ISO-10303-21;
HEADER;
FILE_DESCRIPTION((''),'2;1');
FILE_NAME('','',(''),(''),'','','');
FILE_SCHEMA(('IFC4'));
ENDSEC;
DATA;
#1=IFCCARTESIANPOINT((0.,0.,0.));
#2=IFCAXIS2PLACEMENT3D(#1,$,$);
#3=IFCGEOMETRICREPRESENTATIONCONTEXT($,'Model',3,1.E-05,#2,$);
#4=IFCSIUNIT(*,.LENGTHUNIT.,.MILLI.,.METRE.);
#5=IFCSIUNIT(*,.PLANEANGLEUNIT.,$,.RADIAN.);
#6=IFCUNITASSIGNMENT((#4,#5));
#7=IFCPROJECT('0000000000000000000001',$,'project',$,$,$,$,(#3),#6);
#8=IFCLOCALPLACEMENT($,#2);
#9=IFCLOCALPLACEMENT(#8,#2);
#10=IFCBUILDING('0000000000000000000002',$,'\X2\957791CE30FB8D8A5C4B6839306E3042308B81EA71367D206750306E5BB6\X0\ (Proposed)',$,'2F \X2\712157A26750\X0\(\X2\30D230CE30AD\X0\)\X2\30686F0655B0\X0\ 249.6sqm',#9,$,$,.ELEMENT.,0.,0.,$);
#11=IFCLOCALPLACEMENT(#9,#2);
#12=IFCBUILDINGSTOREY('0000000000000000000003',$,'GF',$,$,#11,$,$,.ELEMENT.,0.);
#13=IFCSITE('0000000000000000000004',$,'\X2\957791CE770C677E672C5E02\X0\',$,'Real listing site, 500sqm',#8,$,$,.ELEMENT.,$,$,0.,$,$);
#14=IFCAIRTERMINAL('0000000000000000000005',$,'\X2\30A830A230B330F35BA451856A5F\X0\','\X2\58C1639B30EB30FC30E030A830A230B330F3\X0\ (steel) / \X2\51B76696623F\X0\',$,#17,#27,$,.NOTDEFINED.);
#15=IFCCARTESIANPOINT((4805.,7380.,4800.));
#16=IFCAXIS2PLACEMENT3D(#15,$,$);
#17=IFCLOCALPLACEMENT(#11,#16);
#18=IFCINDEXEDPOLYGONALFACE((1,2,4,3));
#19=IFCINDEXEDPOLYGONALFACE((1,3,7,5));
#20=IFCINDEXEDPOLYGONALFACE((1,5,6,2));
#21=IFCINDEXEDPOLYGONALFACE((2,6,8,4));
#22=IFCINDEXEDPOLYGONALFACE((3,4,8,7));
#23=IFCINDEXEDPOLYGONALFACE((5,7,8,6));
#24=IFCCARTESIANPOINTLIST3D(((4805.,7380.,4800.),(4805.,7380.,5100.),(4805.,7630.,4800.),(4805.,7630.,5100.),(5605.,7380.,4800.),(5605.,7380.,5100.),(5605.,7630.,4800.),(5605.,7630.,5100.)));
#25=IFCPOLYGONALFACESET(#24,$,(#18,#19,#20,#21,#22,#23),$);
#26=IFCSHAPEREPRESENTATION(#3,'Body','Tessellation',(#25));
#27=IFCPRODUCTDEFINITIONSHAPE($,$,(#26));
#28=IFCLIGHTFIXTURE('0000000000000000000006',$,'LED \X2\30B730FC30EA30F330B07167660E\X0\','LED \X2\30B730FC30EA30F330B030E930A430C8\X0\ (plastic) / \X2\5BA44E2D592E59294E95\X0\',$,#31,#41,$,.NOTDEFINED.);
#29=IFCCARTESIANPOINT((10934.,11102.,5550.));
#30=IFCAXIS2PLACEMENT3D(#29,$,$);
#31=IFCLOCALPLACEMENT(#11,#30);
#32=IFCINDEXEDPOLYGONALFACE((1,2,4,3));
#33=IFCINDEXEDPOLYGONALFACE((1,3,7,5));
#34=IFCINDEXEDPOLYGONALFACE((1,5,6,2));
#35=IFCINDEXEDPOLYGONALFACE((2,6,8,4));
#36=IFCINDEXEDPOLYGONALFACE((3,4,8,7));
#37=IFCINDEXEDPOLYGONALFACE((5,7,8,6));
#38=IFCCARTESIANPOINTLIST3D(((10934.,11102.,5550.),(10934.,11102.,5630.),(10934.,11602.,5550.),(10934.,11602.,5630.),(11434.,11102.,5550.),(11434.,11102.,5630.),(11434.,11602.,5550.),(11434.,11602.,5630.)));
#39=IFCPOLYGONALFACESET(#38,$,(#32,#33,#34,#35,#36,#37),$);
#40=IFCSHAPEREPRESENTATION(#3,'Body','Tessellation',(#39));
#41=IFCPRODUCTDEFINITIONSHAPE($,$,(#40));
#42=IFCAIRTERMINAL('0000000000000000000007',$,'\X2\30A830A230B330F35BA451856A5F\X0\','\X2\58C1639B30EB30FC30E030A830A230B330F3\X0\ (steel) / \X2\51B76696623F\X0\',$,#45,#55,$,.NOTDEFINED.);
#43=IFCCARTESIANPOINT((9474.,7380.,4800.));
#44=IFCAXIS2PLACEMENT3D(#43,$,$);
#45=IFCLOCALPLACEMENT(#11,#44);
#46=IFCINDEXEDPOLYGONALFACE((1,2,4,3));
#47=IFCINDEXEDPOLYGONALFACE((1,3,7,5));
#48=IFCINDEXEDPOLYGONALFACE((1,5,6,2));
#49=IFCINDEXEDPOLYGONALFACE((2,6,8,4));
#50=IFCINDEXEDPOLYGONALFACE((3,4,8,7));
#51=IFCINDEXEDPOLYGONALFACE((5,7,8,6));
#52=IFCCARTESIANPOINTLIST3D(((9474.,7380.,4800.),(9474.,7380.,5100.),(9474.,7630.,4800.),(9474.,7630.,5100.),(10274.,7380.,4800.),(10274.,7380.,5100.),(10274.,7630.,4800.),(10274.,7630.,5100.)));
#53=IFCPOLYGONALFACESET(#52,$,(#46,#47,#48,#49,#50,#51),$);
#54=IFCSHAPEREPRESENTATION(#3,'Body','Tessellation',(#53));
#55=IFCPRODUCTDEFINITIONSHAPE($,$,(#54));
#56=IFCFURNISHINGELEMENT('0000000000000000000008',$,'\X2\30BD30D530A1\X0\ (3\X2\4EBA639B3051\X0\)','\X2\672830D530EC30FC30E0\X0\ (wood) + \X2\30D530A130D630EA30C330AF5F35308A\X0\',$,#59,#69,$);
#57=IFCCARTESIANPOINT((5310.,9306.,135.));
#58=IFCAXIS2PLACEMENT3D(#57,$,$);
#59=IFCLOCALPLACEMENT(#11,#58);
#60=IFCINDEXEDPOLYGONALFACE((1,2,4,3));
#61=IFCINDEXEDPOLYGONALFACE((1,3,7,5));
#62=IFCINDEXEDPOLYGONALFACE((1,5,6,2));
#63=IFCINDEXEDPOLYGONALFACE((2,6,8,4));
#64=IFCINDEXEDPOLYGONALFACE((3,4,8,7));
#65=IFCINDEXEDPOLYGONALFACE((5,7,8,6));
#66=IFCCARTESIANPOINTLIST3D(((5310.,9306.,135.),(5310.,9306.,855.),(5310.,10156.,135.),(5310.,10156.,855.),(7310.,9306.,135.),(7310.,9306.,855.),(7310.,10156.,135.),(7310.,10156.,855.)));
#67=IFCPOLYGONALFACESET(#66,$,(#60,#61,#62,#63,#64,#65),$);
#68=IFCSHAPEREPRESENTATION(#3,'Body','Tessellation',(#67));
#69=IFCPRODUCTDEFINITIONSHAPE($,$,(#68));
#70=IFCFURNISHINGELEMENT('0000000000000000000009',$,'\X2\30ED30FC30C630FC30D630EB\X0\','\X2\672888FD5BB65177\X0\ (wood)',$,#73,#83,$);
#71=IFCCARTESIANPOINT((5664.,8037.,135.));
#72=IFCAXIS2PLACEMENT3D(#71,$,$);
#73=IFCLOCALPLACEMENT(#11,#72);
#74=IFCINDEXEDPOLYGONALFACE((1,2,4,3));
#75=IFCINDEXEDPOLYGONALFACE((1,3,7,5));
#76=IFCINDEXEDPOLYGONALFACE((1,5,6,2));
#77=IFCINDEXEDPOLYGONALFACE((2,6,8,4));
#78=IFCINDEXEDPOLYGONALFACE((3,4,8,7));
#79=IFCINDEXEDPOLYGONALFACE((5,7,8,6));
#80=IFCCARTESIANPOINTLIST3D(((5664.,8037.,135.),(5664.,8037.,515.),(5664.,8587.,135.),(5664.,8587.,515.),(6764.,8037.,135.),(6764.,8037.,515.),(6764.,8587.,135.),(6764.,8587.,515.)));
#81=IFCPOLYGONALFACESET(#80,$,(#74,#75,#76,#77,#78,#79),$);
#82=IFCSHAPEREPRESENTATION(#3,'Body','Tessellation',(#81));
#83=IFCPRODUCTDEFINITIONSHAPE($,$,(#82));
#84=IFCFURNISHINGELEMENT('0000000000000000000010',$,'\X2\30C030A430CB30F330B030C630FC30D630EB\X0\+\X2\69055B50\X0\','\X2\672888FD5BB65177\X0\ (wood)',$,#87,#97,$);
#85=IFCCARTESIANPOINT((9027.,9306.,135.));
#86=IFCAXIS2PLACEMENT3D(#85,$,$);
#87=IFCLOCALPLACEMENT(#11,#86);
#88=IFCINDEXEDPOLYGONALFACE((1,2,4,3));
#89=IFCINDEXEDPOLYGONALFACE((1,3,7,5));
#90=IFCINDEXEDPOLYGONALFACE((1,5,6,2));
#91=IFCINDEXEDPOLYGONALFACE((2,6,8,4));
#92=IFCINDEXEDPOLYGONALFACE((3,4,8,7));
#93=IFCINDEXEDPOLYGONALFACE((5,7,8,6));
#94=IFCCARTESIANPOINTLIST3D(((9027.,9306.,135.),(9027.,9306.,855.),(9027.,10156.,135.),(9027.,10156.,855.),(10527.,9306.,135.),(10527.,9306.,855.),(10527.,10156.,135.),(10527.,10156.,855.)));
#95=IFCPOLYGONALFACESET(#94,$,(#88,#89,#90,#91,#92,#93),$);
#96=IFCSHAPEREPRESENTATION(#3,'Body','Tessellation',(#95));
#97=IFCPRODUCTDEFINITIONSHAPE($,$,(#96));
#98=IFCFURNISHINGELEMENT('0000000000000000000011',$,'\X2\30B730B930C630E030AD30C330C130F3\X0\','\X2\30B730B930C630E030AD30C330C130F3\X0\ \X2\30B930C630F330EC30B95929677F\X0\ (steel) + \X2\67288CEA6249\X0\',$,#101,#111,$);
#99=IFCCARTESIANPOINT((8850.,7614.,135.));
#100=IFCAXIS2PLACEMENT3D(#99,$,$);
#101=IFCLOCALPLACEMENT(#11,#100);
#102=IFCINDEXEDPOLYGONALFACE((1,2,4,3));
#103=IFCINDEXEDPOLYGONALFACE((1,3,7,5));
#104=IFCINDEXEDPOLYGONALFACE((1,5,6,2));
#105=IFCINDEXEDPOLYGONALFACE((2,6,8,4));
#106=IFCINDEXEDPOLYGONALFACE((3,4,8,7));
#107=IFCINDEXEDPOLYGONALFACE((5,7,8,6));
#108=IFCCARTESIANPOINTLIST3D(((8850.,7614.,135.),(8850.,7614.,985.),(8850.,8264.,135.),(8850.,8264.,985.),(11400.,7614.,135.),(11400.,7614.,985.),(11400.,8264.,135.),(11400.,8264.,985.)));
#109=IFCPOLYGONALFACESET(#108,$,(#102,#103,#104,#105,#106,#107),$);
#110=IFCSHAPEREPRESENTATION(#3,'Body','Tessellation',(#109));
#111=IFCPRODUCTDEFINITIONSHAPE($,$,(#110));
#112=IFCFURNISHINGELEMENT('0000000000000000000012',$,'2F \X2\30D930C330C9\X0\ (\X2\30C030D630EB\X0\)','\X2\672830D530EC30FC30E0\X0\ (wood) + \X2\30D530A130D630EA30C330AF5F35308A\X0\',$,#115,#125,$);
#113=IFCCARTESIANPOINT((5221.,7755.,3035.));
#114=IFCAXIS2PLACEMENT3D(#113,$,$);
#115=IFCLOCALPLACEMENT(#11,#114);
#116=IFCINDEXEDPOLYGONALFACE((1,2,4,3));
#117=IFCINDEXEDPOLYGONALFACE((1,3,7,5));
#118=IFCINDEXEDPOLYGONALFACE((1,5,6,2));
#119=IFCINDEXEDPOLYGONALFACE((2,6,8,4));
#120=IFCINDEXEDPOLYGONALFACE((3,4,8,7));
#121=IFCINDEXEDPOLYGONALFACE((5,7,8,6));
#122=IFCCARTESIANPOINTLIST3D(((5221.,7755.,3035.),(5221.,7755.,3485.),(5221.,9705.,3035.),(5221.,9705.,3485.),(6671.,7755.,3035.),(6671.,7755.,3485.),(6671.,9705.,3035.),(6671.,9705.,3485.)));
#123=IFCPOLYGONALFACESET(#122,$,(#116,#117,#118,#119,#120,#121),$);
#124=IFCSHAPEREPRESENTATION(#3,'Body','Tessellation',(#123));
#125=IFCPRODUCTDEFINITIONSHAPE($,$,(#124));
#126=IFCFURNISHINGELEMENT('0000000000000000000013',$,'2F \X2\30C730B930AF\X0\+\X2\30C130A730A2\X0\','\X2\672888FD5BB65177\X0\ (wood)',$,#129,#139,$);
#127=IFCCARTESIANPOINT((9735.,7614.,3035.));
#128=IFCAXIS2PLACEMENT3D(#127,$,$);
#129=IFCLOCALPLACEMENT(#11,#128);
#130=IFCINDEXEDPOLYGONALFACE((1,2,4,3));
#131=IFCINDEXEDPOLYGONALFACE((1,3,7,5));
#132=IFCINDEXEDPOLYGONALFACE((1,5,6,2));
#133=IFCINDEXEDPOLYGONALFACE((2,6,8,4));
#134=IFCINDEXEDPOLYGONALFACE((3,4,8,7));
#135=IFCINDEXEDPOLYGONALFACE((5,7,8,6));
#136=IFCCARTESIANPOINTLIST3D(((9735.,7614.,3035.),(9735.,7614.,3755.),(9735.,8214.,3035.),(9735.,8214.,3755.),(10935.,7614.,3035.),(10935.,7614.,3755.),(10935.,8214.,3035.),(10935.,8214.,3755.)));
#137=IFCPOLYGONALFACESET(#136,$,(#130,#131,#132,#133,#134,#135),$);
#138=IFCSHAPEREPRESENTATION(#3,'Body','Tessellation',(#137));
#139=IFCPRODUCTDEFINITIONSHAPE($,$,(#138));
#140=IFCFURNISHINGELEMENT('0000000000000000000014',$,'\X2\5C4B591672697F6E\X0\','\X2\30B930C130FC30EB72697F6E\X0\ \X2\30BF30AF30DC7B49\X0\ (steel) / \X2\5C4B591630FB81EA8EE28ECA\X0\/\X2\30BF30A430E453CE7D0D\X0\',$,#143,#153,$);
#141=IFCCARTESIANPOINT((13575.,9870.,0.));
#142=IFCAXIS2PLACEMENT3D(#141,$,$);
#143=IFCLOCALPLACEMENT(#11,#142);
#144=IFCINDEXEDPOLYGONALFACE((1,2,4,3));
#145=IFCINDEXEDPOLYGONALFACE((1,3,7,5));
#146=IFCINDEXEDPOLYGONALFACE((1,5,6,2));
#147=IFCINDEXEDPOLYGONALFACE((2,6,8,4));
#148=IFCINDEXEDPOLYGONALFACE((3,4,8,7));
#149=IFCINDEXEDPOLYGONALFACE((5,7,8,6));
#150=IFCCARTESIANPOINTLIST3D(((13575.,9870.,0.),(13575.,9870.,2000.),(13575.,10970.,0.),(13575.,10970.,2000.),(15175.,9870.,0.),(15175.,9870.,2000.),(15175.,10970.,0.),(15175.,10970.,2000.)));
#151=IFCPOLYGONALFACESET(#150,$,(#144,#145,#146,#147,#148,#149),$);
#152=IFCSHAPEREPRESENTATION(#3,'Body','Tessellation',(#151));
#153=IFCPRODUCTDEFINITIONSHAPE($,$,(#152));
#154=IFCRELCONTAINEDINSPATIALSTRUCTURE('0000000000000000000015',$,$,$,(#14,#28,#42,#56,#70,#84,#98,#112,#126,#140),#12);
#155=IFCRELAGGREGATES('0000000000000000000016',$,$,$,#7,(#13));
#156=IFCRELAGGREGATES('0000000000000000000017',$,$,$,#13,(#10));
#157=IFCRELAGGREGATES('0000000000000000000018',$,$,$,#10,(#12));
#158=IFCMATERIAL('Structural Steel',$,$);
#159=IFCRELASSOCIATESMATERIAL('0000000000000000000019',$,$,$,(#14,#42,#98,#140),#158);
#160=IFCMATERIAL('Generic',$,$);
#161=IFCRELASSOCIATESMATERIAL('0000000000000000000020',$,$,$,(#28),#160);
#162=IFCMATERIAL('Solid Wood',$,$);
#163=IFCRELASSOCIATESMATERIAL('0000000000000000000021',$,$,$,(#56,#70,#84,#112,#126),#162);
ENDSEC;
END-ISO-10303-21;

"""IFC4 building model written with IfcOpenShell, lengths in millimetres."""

from ifc_helpers import new_model, si_unit, frame, frame_2d, origin, place, context, project, spatial, rectangle, extrude, material, element, save


model = new_model("IFC4")

# Units and contexts
model_context = context("Model", 3, precision=1e-05, world=origin())
ifc_project = project(units=[si_unit("LENGTHUNIT", "METRE", prefix="MILLI"), si_unit("PLANEANGLEUNIT", "RADIAN")], contexts=[model_context])

# Site, building, storey
site_placement = place(None, origin())
site = spatial("IfcSite", under=ifc_project, at=site_placement, Name="長野県松本市", ObjectType="Real listing site, 500sqm", CompositionType="ELEMENT", RefElevation=0.0)
building_placement = place(site_placement, origin())
building = spatial("IfcBuilding", under=site, at=building_placement, Name="長野・越屋根のある自然素材の家 (Proposed)", ObjectType="2F 無垢材(ヒノキ)と漆喰 249.6sqm", CompositionType="ELEMENT", ElevationOfRefHeight=0.0, ElevationOfTerrain=0.0)
storey_placement = place(building_placement, origin())
storey = spatial("IfcBuildingStorey", under=building, at=storey_placement, Name="GF", CompositionType="ELEMENT", Elevation=0.0)

# Shared definitions
ifc_material_1 = material(Name="Solid Wood")

# Shared definitions
ifc_material_2 = material(Name="Structural Steel")

# Shared definitions
ifc_material_3 = material(Name="Generic")

# Air terminal
air_terminal_1_placement = place(storey_placement, frame((4805.0, 7380.0, 4800.0)))
element("IfcAirTerminal", 1, at=air_terminal_1_placement, inside=storey, material=ifc_material_2, Name="エアコン室内機", Description="壁掛ルームエアコン (steel) / 冷暖房", PredefinedType="NOTDEFINED", context=model_context, shape_type="SweptSolid", body=[
    extrude(rectangle(XDim=800.0, YDim=250.0, at=frame_2d((400.0, 125.0))), frame((4805.0, 7380.0, 4800.0)), (0.0, 0.0, 1.0), 300.0),
])

# Light fixture
light_fixture_1_placement = place(storey_placement, frame((10934.0, 11102.0, 5550.0)))
element("IfcLightFixture", 2, at=light_fixture_1_placement, inside=storey, material=ifc_material_3, Name="LED シーリング照明", Description="LED シーリングライト (plastic) / 室中央天井", PredefinedType="NOTDEFINED", context=model_context, shape_type="SweptSolid", body=[
    extrude(rectangle(XDim=500.0, YDim=500.0, at=frame_2d((250.0, 250.0))), frame((10934.0, 11102.0, 5550.0)), (0.0, 0.0, 1.0), 80.0),
])

# Air terminal
air_terminal_2_placement = place(storey_placement, frame((9474.0, 7380.0, 4800.0)))
element("IfcAirTerminal", 3, at=air_terminal_2_placement, inside=storey, material=ifc_material_2, Name="エアコン室内機", Description="壁掛ルームエアコン (steel) / 冷暖房", PredefinedType="NOTDEFINED", context=model_context, shape_type="SweptSolid", body=[
    extrude(rectangle(XDim=800.0, YDim=250.0, at=frame_2d((400.0, 125.0))), frame((9474.0, 7380.0, 4800.0)), (0.0, 0.0, 1.0), 300.0),
])

# Furnishing elements
furnishing_1_placement = place(storey_placement, frame((5310.0, 9306.0, 135.0)))
element("IfcFurnishingElement", 4, at=furnishing_1_placement, inside=storey, material=ifc_material_1, Name="ソファ (3人掛け)", Description="木フレーム (wood) + ファブリック張り", context=model_context, shape_type="SweptSolid", body=[
    extrude(rectangle(XDim=2000.0, YDim=850.0, at=frame_2d((1000.0, 425.0))), frame((5310.0, 9306.0, 135.0)), (0.0, 0.0, 1.0), 720.0),
])
furnishing_2_placement = place(storey_placement, frame((5664.0, 8037.0, 135.0)))
element("IfcFurnishingElement", 5, at=furnishing_2_placement, inside=storey, material=ifc_material_1, Name="ローテーブル", Description="木製家具 (wood)", context=model_context, shape_type="SweptSolid", body=[
    extrude(rectangle(XDim=1100.0, YDim=550.0, at=frame_2d((550.0, 275.0))), frame((5664.0, 8037.0, 135.0)), (0.0, 0.0, 1.0), 380.0),
])
furnishing_3_placement = place(storey_placement, frame((9027.0, 9306.0, 135.0)))
element("IfcFurnishingElement", 6, at=furnishing_3_placement, inside=storey, material=ifc_material_1, Name="ダイニングテーブル+椅子", Description="木製家具 (wood)", context=model_context, shape_type="SweptSolid", body=[
    extrude(rectangle(XDim=1500.0, YDim=850.0, at=frame_2d((750.0, 425.0))), frame((9027.0, 9306.0, 135.0)), (0.0, 0.0, 1.0), 720.0),
])
furnishing_4_placement = place(storey_placement, frame((8850.0, 7614.0, 135.0)))
element("IfcFurnishingElement", 7, at=furnishing_4_placement, inside=storey, material=ifc_material_2, Name="システムキッチン", Description="システムキッチン ステンレス天板 (steel) + 木質扉", context=model_context, shape_type="SweptSolid", body=[
    extrude(rectangle(XDim=2550.0, YDim=650.0, at=frame_2d((1275.0, 325.0))), frame((8850.0, 7614.0, 135.0)), (0.0, 0.0, 1.0), 850.0),
])
furnishing_5_placement = place(storey_placement, frame((5221.0, 7755.0, 3035.0)))
element("IfcFurnishingElement", 8, at=furnishing_5_placement, inside=storey, material=ifc_material_1, Name="2F ベッド (ダブル)", Description="木フレーム (wood) + ファブリック張り", context=model_context, shape_type="SweptSolid", body=[
    extrude(rectangle(XDim=1450.0, YDim=1950.0, at=frame_2d((725.0, 975.0))), frame((5221.0, 7755.0, 3035.0)), (0.0, 0.0, 1.0), 450.0),
])
furnishing_6_placement = place(storey_placement, frame((9735.0, 7614.0, 3035.0)))
element("IfcFurnishingElement", 9, at=furnishing_6_placement, inside=storey, material=ifc_material_1, Name="2F デスク+チェア", Description="木製家具 (wood)", context=model_context, shape_type="SweptSolid", body=[
    extrude(rectangle(XDim=1200.0, YDim=600.0, at=frame_2d((600.0, 300.0))), frame((9735.0, 7614.0, 3035.0)), (0.0, 0.0, 1.0), 720.0),
])
furnishing_7_placement = place(storey_placement, frame((13575.0, 9870.0, 0.0)))
element("IfcFurnishingElement", 10, at=furnishing_7_placement, inside=storey, material=ifc_material_2, Name="屋外物置", Description="スチール物置 タクボ等 (steel) / 屋外・自転車/タイヤ収納", context=model_context, shape_type="SweptSolid", body=[
    extrude(rectangle(XDim=1600.0, YDim=1100.0, at=frame_2d((800.0, 550.0))), frame((13575.0, 9870.0, 0.0)), (0.0, 0.0, 1.0), 2000.0),
])

save(model, "model.ifc")
